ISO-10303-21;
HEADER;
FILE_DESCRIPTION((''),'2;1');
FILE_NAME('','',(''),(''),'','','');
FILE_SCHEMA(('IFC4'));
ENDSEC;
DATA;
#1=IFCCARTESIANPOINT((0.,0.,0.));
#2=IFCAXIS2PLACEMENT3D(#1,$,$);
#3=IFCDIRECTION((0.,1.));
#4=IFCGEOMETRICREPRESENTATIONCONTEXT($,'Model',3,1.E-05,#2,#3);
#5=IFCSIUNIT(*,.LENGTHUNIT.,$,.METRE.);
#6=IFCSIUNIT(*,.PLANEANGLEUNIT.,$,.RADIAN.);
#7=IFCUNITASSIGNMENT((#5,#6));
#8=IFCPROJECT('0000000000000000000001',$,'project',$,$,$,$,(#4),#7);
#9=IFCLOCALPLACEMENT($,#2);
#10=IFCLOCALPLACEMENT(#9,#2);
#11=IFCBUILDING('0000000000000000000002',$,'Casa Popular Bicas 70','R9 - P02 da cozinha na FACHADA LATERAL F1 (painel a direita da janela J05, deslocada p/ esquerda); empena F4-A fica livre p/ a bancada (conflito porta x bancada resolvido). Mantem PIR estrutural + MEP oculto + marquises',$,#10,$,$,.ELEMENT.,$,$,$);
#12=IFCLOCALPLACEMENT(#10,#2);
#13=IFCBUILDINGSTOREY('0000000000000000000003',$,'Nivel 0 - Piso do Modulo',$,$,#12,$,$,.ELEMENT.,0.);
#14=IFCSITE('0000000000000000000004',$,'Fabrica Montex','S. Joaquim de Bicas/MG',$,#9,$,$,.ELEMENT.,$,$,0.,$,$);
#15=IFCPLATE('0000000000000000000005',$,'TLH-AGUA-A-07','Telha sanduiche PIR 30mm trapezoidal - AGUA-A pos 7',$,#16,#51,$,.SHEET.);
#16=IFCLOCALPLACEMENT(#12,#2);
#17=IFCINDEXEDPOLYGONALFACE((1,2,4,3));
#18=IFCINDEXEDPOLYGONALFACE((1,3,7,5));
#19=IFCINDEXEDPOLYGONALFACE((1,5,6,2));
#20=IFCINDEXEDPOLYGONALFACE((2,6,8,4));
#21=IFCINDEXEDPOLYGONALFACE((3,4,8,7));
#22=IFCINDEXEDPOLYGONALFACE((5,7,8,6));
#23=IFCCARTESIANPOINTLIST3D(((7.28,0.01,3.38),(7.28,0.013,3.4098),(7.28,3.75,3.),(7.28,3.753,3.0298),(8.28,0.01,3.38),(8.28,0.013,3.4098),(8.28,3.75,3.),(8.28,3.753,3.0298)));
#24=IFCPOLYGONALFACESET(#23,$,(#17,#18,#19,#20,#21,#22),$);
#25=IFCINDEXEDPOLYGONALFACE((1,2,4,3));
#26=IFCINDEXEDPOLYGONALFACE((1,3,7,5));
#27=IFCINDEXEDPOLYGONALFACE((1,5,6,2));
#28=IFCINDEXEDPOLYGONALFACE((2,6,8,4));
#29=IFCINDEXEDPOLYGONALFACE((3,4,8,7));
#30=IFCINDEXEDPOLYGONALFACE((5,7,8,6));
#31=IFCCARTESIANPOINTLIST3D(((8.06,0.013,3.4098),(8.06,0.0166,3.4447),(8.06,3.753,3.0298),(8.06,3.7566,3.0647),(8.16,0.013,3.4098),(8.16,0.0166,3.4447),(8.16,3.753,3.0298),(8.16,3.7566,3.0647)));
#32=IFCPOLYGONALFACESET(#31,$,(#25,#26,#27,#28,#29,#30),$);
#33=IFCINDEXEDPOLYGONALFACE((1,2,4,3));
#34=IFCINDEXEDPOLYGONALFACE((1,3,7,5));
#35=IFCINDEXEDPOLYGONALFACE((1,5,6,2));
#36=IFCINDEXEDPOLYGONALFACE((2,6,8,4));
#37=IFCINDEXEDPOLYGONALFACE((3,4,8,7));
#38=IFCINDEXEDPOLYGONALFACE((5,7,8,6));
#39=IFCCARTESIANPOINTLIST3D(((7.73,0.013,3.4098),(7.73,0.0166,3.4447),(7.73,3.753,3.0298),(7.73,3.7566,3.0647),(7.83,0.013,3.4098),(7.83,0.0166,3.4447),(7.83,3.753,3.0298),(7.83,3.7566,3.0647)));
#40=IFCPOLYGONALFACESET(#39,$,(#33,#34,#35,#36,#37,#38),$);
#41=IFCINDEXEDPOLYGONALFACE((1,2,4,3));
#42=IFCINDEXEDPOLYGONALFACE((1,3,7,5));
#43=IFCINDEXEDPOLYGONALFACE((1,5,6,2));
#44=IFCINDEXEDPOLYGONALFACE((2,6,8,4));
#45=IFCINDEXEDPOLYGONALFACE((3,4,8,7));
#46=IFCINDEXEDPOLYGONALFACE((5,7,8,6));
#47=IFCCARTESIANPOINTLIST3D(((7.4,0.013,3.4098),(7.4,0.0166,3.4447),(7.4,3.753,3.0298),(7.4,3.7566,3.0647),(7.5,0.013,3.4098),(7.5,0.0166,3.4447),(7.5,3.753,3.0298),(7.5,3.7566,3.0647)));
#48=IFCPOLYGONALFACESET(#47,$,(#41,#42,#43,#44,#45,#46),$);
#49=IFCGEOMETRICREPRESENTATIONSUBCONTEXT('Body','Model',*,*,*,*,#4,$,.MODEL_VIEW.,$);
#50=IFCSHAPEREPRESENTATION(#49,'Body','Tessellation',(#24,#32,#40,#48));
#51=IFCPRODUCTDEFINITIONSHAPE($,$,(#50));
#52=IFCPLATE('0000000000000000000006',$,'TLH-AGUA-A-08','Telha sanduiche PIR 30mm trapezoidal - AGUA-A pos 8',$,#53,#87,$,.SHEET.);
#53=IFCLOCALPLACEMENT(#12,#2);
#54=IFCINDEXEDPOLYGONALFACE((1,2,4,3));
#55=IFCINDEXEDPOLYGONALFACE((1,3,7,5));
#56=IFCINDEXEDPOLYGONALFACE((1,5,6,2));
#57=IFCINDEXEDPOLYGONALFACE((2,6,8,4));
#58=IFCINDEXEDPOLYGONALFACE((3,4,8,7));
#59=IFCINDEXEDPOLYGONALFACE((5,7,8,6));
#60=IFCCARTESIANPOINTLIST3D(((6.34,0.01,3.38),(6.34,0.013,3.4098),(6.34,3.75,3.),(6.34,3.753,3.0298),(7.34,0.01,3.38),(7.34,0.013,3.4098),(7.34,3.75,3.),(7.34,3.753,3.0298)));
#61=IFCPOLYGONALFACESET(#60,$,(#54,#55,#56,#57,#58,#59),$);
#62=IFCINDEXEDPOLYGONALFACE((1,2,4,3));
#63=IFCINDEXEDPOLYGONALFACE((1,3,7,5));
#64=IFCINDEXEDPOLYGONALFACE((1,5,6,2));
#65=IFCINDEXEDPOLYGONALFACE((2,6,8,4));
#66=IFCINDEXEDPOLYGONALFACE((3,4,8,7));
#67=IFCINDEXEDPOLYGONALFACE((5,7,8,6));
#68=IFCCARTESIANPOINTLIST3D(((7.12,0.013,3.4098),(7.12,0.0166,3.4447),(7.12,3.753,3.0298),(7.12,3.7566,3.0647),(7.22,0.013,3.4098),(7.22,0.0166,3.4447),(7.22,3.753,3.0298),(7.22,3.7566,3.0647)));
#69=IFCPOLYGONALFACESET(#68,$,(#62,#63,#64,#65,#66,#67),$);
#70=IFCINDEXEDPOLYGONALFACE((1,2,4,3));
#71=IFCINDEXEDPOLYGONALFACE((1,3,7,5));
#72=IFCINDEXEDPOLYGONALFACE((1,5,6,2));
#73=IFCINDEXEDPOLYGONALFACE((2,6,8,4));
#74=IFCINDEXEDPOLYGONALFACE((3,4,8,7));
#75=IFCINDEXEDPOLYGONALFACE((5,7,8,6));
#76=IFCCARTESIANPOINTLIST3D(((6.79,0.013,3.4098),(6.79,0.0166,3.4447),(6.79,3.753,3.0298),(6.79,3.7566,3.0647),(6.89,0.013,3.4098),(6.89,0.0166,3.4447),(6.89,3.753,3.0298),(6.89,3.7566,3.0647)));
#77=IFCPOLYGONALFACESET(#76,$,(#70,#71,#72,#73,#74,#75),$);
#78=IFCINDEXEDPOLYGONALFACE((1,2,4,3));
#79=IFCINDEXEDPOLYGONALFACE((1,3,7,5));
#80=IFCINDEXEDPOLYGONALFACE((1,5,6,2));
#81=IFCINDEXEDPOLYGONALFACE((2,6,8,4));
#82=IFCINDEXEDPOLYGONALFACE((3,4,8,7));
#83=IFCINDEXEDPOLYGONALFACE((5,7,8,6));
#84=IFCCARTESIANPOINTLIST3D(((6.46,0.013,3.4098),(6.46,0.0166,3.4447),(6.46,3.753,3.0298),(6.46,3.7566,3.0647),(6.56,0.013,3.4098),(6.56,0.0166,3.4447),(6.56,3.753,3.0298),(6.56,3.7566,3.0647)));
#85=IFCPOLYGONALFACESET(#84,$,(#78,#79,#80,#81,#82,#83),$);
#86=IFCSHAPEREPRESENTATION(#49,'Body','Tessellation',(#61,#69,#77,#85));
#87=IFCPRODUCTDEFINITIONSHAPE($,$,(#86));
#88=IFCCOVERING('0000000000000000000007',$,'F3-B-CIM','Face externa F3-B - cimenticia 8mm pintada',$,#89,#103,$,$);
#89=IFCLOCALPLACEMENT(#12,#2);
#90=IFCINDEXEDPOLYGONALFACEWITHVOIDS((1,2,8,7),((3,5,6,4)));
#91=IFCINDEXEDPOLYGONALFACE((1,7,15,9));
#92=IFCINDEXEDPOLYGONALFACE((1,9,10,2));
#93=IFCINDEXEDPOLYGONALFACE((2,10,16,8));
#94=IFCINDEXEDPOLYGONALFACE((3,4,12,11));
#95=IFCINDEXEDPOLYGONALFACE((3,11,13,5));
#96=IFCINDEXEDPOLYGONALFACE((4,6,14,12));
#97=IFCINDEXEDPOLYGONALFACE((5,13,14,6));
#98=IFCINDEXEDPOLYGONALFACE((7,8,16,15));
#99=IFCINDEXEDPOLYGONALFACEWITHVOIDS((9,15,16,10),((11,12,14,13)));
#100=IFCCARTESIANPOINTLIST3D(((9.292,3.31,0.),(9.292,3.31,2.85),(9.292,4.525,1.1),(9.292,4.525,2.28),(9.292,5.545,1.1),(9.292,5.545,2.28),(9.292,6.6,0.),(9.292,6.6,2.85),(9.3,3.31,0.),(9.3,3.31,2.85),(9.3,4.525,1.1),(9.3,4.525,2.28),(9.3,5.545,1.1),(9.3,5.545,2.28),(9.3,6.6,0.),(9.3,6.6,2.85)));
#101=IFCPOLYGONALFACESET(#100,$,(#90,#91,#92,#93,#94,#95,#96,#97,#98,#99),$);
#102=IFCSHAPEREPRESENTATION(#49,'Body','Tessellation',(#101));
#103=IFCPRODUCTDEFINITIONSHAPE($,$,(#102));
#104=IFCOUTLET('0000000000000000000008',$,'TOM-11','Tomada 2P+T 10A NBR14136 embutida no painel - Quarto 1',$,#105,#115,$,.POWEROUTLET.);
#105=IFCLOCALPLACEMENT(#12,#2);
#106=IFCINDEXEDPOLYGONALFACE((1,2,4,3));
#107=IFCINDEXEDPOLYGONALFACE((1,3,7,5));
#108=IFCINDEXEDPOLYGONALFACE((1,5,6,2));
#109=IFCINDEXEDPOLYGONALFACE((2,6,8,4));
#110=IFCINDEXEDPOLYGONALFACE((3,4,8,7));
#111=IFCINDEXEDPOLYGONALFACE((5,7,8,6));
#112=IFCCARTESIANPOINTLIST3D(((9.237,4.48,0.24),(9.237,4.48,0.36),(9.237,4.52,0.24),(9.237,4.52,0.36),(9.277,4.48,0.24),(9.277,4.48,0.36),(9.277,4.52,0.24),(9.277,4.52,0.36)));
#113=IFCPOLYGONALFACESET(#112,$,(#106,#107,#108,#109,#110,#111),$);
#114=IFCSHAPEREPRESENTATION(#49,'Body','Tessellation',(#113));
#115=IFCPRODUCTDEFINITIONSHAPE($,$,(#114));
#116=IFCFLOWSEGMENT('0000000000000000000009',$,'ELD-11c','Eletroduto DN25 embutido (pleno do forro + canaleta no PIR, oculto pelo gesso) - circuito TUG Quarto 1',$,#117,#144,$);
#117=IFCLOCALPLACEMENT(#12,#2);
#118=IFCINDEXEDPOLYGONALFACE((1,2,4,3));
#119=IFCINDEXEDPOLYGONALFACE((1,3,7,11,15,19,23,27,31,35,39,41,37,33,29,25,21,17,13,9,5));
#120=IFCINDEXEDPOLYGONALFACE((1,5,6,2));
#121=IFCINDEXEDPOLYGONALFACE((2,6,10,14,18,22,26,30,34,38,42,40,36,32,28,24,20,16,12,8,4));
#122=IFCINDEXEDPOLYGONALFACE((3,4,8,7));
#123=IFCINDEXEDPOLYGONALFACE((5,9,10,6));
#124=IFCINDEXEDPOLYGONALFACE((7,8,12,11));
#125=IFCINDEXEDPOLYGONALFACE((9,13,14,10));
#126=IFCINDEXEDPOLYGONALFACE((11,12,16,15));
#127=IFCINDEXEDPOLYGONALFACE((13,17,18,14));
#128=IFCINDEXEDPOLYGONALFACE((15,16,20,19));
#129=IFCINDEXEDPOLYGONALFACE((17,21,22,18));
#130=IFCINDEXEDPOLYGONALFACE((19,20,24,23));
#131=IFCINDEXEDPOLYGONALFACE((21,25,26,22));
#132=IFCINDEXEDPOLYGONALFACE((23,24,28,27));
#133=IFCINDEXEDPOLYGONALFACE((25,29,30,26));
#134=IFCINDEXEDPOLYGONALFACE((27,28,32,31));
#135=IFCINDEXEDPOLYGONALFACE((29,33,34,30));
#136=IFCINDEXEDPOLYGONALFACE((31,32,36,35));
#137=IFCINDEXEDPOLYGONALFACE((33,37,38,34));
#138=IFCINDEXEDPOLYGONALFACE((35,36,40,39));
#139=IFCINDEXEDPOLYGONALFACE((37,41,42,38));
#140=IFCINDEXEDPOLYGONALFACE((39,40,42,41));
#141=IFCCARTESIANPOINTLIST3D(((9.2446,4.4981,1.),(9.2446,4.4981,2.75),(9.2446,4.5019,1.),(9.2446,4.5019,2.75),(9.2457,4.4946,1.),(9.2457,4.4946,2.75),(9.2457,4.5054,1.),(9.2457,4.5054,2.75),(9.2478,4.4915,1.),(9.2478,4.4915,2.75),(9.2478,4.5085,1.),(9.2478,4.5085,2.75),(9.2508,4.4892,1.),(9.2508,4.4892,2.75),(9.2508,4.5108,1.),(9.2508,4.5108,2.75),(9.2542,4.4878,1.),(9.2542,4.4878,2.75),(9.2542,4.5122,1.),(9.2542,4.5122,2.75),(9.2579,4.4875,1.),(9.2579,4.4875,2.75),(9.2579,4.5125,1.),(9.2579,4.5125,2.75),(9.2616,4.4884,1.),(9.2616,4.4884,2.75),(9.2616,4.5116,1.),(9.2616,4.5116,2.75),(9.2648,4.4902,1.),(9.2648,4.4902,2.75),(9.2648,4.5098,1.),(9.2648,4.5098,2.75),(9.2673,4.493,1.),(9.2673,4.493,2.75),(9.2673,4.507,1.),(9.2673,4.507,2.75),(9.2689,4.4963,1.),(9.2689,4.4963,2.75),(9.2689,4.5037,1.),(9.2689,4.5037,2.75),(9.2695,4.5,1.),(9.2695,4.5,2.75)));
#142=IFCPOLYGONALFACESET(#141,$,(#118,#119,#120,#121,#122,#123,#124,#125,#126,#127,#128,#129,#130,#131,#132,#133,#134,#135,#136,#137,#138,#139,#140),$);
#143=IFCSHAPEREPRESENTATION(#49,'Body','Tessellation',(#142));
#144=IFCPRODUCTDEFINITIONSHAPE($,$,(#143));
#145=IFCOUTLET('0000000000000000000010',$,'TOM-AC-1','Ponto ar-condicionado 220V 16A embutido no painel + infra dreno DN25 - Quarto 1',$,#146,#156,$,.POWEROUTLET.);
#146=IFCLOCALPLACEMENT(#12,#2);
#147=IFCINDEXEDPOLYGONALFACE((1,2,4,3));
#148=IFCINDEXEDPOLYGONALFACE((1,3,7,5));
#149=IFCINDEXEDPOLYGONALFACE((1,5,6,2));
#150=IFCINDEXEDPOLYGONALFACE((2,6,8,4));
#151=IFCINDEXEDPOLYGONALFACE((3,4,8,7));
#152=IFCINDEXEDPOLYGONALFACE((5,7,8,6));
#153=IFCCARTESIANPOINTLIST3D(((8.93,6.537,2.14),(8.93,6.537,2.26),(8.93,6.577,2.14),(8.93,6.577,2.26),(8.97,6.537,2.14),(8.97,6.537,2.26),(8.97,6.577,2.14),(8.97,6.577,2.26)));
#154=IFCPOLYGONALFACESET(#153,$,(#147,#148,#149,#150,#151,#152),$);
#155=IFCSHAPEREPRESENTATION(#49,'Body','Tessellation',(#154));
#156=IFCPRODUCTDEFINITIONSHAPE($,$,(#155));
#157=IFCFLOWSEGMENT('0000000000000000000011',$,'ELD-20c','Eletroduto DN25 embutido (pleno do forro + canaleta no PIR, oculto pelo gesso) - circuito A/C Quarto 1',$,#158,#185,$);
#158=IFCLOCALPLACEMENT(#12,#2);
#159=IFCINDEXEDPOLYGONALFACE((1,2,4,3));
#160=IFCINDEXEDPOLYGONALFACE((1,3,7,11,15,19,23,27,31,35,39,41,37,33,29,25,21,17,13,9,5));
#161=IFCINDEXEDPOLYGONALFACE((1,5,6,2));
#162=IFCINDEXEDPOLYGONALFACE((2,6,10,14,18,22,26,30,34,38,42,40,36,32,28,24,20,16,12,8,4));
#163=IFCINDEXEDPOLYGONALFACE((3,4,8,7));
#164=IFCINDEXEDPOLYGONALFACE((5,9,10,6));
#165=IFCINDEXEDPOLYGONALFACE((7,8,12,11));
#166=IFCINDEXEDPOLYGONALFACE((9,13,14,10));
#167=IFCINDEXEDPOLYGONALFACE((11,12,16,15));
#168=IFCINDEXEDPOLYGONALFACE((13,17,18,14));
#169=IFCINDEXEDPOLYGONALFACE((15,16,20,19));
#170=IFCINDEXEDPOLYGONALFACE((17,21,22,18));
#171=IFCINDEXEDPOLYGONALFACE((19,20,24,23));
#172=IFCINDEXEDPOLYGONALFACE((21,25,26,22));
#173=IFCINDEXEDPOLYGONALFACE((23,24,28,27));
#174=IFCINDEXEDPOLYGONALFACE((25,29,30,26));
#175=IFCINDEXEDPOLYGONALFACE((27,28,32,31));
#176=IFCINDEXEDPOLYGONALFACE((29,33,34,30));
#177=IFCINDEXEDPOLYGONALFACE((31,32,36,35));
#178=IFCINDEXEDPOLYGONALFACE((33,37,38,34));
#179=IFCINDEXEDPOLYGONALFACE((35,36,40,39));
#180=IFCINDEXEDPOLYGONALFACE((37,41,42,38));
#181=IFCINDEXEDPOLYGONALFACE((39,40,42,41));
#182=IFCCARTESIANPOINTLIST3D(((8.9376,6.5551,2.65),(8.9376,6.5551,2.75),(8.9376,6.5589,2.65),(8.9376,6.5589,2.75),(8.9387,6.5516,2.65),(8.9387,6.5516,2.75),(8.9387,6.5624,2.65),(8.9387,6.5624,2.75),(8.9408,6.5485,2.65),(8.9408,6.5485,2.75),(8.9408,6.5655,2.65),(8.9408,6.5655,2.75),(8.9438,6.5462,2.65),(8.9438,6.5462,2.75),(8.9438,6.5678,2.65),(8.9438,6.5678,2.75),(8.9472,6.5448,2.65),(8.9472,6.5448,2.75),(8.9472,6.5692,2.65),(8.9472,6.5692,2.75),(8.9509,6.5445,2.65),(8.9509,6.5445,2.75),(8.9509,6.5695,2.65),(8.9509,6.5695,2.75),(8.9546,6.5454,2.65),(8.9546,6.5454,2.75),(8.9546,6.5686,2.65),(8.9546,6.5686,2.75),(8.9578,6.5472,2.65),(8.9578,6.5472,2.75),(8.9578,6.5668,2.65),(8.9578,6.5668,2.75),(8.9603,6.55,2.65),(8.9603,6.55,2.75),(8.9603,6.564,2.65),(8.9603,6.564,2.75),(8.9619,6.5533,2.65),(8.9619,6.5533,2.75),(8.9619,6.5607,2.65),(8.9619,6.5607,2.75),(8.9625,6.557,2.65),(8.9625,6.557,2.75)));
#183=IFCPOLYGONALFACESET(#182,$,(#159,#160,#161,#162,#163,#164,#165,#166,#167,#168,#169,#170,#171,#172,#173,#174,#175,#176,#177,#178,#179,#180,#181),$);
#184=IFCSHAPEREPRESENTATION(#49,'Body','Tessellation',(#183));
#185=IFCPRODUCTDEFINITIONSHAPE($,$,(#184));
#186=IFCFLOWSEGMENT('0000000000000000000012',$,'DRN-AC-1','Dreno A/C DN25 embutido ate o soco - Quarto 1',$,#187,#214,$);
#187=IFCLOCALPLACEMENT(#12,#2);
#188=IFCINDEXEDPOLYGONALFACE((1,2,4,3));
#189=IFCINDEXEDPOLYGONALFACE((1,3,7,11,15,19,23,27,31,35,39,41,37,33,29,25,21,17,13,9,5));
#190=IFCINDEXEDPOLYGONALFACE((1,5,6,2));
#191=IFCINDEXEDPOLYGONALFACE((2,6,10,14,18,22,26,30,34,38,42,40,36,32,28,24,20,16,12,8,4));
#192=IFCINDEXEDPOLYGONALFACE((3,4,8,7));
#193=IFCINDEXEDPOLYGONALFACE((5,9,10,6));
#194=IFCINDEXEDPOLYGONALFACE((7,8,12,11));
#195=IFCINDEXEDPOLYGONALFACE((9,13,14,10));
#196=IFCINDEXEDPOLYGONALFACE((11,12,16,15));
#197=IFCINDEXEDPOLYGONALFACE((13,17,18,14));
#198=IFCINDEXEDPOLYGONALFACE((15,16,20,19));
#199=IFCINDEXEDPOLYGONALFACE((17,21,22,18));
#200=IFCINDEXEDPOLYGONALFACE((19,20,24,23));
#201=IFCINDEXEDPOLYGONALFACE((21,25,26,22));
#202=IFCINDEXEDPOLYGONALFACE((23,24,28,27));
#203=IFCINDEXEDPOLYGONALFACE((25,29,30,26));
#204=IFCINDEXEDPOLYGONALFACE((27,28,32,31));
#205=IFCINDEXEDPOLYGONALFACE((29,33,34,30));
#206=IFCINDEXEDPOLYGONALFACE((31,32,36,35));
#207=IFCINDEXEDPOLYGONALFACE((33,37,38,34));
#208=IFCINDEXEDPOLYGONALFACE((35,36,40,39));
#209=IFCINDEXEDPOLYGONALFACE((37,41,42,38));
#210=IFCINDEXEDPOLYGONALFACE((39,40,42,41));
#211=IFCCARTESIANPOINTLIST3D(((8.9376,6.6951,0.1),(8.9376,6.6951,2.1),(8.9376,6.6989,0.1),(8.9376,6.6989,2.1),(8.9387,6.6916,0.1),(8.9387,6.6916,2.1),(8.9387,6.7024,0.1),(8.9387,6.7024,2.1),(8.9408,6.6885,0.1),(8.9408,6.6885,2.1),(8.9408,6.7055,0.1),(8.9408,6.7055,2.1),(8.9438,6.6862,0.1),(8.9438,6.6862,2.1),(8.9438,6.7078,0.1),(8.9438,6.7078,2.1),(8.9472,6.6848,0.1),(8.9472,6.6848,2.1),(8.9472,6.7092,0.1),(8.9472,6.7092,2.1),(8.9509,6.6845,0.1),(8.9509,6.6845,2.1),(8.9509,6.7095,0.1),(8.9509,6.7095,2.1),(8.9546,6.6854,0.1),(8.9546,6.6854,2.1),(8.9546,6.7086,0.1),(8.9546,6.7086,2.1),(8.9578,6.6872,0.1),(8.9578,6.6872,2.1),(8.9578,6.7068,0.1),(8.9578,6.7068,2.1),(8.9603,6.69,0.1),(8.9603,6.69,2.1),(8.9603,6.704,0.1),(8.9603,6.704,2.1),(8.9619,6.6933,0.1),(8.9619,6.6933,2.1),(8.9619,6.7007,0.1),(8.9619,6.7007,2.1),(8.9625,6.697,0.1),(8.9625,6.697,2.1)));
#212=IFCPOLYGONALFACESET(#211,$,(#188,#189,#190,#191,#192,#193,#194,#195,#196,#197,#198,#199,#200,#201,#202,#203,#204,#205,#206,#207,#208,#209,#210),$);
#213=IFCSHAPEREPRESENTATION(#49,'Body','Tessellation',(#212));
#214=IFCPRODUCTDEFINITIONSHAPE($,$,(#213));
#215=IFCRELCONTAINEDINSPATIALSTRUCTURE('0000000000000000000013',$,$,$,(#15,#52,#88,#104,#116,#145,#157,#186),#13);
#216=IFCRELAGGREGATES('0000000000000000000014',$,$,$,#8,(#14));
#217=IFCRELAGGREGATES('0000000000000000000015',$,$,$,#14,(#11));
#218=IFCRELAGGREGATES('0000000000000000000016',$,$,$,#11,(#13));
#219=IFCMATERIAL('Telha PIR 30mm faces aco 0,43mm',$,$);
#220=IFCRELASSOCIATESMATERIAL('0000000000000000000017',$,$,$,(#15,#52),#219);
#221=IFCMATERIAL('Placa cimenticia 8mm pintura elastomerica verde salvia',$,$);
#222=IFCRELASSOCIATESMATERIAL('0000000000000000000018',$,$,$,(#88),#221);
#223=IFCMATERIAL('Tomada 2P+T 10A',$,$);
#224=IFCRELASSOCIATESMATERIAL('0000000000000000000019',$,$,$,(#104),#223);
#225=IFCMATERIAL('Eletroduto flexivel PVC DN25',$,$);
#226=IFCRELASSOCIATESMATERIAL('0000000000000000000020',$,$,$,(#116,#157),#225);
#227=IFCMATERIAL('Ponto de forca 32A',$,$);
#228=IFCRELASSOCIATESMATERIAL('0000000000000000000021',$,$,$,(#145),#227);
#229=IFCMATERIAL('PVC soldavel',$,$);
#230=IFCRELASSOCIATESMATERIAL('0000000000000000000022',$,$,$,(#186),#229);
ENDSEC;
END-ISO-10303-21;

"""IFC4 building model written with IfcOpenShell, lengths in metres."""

from ifc_helpers import new_model, si_unit, direction, frame, frame_2d, origin, origin_2d, place, context, subcontext, project, spatial, rectangle, circle, extrude, material, element, save


model = new_model("IFC4")

# Units and contexts
model_context = context("Model", 3, precision=1e-05, world=origin(), true_north=direction((0.0, 1.0)))
body_context = subcontext(model_context, "Body", "Model", "MODEL_VIEW")
ifc_project = project(units=[si_unit("LENGTHUNIT", "METRE"), si_unit("PLANEANGLEUNIT", "RADIAN")], contexts=[model_context])

# Site, building, storey
site_placement = place(None, origin())
site = spatial("IfcSite", under=ifc_project, at=site_placement, Name="Fabrica Montex", Description="S. Joaquim de Bicas/MG", CompositionType="ELEMENT", RefElevation=0.0)
building_placement = place(site_placement, origin())
building = spatial("IfcBuilding", under=site, at=building_placement, Name="Casa Popular Bicas 70", Description="R9 - P02 da cozinha na FACHADA LATERAL F1 (painel a direita da janela J05, deslocada p/ esquerda); empena F4-A fica livre p/ a bancada (conflito porta x bancada resolvido). Mantem PIR estrutural + MEP oculto + marquises", CompositionType="ELEMENT")
storey_placement = place(building_placement, origin())
storey = spatial("IfcBuildingStorey", under=building, at=storey_placement, Name="Nivel 0 - Piso do Modulo", CompositionType="ELEMENT", Elevation=0.0)

# Plates
ifc_material_1 = material(Name="Telha PIR 30mm faces aco 0,43mm")
for number, where, z_axis, x_axis, name, description in (
    (1, (8.28, 3.75, 3.0), (0.0, 0.101084, 0.994878), (-1.0, 0.0, 0.0), "TLH-AGUA-A-07", "Telha sanduiche PIR 30mm trapezoidal - AGUA-A pos 7"),
    (2, (7.34, 3.75, 3.0), (0.0, 0.101084, 0.994878), (-1.0, 0.0, 0.0), "TLH-AGUA-A-08", "Telha sanduiche PIR 30mm trapezoidal - AGUA-A pos 8"),
):
    element("IfcPlate", number, at=place(None, frame(where, z_axis=z_axis, x_axis=x_axis)), inside=storey, material=ifc_material_1, Name=name, Description=description, PredefinedType="SHEET", context=body_context, shape_type="SweptSolid", body=[
        extrude(rectangle(XDim=1.0, YDim=3.7593, at=frame_2d((0.5, 1.8796))), origin(), (0.0, 0.0, 1.0), 0.03),
        extrude(rectangle(XDim=0.1, YDim=3.7593, at=frame_2d((0.17, 1.8796))), frame((0.0, 0.0, 0.03)), (0.0, 0.0, 1.0), 0.035),
        extrude(rectangle(XDim=0.1, YDim=3.7593, at=frame_2d((0.5, 1.8796))), frame((0.0, 0.0, 0.03)), (0.0, 0.0, 1.0), 0.035),
        extrude(rectangle(XDim=0.1, YDim=3.7593, at=frame_2d((0.83, 1.8796))), frame((0.0, 0.0, 0.03)), (0.0, 0.0, 1.0), 0.035),
    ])

# Covering, opening
ifc_material_2 = material(Name="Placa cimenticia 8mm pintura elastomerica verde salvia")
covering_1_placement = place(storey_placement, frame((9.296, 3.31, 0.0), x_axis=(0.0, 1.0, 0.0)))
covering_1 = element("IfcCovering", 3, at=covering_1_placement, inside=storey, material=ifc_material_2, Name="F3-B-CIM", Description="Face externa F3-B - cimenticia 8mm pintada", context=body_context, shape_type="SweptSolid", body=[
    extrude(rectangle(XDim=3.29, YDim=0.008, at=frame_2d((1.645, 0.0))), origin(), (0.0, 0.0, 1.0), 2.85),
])
opening_1_placement = place(storey_placement, frame((9.296, 4.535, 1.1), x_axis=(0.0, 1.0, 0.0)))
element("IfcOpeningElement", 4, at=opening_1_placement, cuts=covering_1, PredefinedType="OPENING", context=body_context, shape_type="SweptSolid", body=[
    extrude(rectangle(XDim=1.02, YDim=0.03, at=frame_2d((0.5, 0.0))), origin(), (0.0, 0.0, 1.0), 1.18),
])

# Outlet
ifc_material_3 = material(Name="Tomada 2P+T 10A")
outlet_1_placement = place(storey_placement, frame((9.237, 4.48, 0.24)))
element("IfcOutlet", 5, at=outlet_1_placement, inside=storey, material=ifc_material_3, Name="TOM-11", Description="Tomada 2P+T 10A NBR14136 embutida no painel - Quarto 1", PredefinedType="POWEROUTLET", context=body_context, shape_type="SweptSolid", body=[
    extrude(rectangle(XDim=0.04, YDim=0.04, at=frame_2d((0.02, 0.02))), origin(), (0.0, 0.0, 1.0), 0.12),
])

# Flow segment
ifc_material_4 = material(Name="Eletroduto flexivel PVC DN25")
flow_segment_1_placement = place(storey_placement, frame((9.257, 4.5, 2.75), z_axis=(0.0, 0.0, -1.0), x_axis=(1.0, 0.0, 0.0)))
element("IfcFlowSegment", 6, at=flow_segment_1_placement, inside=storey, material=ifc_material_4, Name="ELD-11c", Description="Eletroduto DN25 embutido (pleno do forro + canaleta no PIR, oculto pelo gesso) - circuito TUG Quarto 1", context=body_context, shape_type="SweptSolid", body=[
    extrude(circle(Radius=0.0125, at=origin_2d()), origin(), (0.0, 0.0, 1.0), 1.75),
])

# Outlet
ifc_material_5 = material(Name="Ponto de forca 32A")
outlet_2_placement = place(storey_placement, frame((8.93, 6.537, 2.14)))
element("IfcOutlet", 7, at=outlet_2_placement, inside=storey, material=ifc_material_5, Name="TOM-AC-1", Description="Ponto ar-condicionado 220V 16A embutido no painel + infra dreno DN25 - Quarto 1", PredefinedType="POWEROUTLET", context=body_context, shape_type="SweptSolid", body=[
    extrude(rectangle(XDim=0.04, YDim=0.04, at=frame_2d((0.02, 0.02))), origin(), (0.0, 0.0, 1.0), 0.12),
])

# Flow segments
flow_segment_2_placement = place(storey_placement, frame((8.95, 6.557, 2.75), z_axis=(0.0, 0.0, -1.0), x_axis=(1.0, 0.0, 0.0)))
element("IfcFlowSegment", 8, at=flow_segment_2_placement, inside=storey, material=ifc_material_4, Name="ELD-20c", Description="Eletroduto DN25 embutido (pleno do forro + canaleta no PIR, oculto pelo gesso) - circuito A/C Quarto 1", context=body_context, shape_type="SweptSolid", body=[
    extrude(circle(Radius=0.0125, at=origin_2d()), origin(), (0.0, 0.0, 1.0), 0.1),
])
ifc_material_6 = material(Name="PVC soldavel")
flow_segment_3_placement = place(storey_placement, frame((8.95, 6.697, 2.1), z_axis=(0.0, 0.0, -1.0), x_axis=(1.0, 0.0, 0.0)))
element("IfcFlowSegment", 9, at=flow_segment_3_placement, inside=storey, material=ifc_material_6, Name="DRN-AC-1", Description="Dreno A/C DN25 embutido ate o soco - Quarto 1", context=body_context, shape_type="SweptSolid", body=[
    extrude(circle(Radius=0.0125, at=origin_2d()), origin(), (0.0, 0.0, 1.0), 2.0),
])

save(model, "model.ifc")
